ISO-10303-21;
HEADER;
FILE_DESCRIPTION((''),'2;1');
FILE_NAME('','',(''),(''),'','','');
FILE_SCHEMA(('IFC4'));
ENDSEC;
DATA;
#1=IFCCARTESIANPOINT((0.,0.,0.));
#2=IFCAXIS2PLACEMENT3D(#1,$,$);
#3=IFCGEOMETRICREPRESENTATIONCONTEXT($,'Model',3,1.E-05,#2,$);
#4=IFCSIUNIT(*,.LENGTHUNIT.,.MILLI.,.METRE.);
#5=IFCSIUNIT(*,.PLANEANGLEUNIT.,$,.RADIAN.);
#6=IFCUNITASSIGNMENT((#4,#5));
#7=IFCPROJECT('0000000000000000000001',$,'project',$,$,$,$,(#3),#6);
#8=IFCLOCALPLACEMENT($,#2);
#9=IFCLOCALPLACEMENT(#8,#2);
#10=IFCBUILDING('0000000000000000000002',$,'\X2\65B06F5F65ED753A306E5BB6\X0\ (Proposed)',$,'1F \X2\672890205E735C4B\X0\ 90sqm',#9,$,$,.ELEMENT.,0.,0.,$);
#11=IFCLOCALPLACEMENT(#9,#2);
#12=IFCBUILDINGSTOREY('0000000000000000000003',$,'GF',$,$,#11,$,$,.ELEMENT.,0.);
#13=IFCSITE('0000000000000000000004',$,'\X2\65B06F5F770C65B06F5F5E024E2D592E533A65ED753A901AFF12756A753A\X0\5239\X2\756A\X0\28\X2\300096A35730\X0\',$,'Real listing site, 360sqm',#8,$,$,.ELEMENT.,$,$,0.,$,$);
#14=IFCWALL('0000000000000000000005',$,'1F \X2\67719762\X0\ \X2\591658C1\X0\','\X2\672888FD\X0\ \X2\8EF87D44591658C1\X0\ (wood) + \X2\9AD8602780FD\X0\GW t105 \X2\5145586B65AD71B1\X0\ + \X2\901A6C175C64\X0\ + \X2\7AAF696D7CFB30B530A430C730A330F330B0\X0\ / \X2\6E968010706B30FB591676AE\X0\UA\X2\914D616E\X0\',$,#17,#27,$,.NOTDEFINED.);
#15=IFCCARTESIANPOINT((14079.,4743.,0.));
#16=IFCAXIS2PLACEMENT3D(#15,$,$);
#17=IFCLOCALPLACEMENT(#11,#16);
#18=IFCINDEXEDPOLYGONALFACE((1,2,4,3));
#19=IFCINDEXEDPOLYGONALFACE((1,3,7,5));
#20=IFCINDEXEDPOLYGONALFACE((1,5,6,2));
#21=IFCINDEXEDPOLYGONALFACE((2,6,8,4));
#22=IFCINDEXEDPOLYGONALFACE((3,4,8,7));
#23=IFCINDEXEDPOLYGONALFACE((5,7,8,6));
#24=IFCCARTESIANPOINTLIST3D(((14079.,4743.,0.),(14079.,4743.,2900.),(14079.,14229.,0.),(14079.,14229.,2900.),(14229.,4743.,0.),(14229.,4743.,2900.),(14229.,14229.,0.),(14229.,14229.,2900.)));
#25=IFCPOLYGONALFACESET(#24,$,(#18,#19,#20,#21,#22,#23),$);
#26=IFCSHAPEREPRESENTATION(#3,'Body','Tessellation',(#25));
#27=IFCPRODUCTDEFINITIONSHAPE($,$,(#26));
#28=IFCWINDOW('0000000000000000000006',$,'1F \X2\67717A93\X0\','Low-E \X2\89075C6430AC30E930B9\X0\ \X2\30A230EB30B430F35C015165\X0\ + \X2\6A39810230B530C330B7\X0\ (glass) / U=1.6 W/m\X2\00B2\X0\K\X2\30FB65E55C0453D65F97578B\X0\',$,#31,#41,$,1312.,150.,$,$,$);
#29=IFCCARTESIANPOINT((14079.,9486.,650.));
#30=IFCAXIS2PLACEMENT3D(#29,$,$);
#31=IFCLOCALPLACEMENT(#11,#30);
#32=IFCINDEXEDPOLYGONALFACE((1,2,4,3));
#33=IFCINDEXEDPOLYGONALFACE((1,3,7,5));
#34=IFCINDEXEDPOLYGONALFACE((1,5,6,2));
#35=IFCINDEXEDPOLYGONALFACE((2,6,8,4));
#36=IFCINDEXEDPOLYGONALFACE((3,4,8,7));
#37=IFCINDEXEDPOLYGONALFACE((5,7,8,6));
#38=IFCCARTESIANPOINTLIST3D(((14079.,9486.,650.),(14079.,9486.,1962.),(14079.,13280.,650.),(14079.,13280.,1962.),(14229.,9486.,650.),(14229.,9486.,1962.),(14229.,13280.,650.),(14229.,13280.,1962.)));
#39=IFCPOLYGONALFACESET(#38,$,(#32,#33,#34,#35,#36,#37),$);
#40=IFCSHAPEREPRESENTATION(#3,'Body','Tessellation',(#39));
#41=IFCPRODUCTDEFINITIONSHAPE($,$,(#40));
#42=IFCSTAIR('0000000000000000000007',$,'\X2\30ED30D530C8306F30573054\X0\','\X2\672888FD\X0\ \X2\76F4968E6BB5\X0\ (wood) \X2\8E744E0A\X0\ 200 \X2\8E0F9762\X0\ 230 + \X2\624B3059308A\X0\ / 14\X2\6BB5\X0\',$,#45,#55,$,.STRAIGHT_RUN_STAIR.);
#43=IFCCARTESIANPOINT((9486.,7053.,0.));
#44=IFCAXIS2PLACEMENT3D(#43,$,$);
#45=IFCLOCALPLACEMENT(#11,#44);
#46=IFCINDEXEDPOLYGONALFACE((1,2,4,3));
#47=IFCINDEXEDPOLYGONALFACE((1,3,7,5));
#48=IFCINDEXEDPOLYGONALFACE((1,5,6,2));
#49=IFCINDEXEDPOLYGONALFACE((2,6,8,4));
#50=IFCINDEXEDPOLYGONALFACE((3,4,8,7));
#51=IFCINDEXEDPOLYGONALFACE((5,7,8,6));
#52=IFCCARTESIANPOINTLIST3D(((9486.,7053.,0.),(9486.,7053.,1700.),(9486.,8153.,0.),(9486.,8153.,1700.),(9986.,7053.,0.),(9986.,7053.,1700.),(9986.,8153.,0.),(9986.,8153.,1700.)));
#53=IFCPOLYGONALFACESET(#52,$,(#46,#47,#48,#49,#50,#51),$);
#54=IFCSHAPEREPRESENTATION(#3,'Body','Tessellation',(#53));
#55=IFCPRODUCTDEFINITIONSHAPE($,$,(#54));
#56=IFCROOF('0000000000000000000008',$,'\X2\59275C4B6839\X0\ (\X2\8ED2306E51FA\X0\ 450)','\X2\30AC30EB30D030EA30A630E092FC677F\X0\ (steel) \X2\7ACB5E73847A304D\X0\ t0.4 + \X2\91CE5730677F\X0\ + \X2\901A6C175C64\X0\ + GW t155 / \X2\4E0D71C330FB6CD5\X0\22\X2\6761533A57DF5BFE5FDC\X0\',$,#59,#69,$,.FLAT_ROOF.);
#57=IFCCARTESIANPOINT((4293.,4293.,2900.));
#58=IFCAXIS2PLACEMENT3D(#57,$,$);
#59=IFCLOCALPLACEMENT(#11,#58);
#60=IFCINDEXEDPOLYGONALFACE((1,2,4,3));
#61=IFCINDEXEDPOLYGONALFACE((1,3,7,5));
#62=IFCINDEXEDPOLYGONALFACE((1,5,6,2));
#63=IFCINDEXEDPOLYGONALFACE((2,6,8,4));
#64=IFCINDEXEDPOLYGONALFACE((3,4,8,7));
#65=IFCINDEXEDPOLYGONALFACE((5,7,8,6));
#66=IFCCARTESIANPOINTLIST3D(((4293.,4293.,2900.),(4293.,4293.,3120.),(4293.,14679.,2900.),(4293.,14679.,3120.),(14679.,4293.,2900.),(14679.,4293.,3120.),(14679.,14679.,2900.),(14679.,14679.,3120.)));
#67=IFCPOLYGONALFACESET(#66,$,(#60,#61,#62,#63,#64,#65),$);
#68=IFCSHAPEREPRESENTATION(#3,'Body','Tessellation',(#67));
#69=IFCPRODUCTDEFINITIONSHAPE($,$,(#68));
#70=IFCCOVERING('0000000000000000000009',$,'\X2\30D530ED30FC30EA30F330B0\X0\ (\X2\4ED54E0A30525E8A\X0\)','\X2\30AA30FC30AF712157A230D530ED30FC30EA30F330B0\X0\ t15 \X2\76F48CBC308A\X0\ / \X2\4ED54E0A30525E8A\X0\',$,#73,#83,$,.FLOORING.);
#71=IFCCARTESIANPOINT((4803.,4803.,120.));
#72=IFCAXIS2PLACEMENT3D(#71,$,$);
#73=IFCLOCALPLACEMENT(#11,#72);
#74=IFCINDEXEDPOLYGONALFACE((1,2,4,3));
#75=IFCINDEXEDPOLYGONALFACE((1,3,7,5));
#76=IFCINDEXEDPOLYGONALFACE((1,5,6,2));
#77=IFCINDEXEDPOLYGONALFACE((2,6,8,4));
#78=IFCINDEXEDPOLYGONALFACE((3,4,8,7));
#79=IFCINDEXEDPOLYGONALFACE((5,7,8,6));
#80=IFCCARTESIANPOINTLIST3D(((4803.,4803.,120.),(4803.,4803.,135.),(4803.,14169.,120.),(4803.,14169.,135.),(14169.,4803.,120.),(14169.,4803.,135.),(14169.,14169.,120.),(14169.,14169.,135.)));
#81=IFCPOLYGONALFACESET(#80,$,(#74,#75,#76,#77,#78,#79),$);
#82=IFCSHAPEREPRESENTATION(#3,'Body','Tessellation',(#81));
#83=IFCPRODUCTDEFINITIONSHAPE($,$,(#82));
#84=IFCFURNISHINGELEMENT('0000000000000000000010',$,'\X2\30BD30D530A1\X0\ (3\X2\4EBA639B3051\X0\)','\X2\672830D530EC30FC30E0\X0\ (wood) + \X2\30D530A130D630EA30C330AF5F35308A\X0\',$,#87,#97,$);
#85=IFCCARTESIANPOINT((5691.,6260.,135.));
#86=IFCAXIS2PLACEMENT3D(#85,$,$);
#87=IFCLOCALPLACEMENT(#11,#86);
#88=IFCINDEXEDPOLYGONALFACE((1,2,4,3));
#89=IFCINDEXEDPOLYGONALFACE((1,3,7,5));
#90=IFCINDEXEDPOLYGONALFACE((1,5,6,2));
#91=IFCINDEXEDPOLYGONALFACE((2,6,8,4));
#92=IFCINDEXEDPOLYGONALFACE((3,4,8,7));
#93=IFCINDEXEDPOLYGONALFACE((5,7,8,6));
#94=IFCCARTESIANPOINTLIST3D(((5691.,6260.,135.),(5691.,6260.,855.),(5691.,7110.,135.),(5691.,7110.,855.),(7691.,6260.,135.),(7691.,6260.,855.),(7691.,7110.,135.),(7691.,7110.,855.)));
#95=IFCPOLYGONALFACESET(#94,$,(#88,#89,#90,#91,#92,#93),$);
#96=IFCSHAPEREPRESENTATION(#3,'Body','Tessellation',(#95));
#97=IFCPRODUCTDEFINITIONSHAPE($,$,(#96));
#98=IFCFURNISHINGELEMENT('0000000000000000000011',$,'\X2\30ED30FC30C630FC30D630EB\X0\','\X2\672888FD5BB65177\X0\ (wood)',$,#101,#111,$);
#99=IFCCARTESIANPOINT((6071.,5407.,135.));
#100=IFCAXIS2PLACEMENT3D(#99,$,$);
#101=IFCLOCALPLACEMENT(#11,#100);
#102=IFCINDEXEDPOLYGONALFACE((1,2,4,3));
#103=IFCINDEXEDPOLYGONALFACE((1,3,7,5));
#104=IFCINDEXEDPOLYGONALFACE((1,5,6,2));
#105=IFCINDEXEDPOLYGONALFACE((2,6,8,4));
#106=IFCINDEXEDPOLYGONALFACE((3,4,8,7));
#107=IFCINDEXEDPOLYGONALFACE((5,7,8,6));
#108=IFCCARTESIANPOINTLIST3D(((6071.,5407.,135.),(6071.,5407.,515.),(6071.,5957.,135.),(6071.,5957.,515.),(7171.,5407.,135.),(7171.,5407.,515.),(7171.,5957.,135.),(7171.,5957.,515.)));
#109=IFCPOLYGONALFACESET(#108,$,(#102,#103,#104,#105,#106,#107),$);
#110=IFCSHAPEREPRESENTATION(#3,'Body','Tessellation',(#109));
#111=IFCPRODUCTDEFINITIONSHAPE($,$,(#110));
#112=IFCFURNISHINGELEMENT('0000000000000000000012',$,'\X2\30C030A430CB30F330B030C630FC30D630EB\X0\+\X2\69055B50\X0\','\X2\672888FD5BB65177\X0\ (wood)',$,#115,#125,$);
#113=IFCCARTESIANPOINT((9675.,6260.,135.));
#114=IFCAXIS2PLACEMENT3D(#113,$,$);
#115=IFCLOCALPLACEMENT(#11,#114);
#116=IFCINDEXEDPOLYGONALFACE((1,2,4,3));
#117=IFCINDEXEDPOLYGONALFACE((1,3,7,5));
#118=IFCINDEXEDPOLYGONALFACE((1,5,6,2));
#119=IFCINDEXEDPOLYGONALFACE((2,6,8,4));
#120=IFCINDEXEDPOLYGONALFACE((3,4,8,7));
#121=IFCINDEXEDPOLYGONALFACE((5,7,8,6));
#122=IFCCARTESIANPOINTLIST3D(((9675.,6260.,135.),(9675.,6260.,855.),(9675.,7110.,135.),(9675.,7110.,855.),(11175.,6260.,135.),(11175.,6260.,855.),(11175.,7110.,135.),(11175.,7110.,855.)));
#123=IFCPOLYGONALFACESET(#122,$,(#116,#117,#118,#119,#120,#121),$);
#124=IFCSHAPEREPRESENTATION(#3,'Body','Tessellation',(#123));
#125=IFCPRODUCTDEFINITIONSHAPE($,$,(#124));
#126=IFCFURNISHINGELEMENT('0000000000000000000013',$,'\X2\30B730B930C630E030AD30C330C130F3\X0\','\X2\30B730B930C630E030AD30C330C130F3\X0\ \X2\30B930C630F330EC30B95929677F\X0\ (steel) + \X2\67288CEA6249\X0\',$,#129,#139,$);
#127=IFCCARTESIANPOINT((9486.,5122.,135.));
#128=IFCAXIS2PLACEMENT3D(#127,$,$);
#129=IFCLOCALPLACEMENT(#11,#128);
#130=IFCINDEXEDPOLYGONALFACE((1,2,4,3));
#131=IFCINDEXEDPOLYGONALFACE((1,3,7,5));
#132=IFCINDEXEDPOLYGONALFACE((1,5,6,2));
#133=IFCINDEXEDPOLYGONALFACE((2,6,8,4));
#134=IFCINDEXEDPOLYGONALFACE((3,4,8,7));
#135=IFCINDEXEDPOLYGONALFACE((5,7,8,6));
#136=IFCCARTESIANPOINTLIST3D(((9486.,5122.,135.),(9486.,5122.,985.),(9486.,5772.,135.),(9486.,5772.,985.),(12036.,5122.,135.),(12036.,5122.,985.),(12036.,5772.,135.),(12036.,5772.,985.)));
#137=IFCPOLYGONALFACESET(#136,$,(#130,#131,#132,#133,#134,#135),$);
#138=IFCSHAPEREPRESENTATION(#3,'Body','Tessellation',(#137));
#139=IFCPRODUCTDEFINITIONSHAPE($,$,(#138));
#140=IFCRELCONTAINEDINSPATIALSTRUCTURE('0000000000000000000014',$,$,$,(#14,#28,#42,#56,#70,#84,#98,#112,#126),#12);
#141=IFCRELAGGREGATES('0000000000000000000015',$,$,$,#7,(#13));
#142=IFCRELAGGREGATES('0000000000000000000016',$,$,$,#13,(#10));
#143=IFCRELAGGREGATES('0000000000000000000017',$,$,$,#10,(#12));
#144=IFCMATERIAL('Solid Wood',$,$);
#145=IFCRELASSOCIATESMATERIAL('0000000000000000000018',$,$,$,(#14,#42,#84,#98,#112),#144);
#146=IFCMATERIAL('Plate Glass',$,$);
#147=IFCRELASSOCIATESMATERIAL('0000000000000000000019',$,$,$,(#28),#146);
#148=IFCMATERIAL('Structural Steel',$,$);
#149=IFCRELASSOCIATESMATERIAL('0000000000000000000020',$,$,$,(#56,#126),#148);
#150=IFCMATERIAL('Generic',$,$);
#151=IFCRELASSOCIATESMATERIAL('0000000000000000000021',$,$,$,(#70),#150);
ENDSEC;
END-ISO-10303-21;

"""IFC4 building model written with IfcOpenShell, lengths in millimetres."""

from ifc_helpers import new_model, si_unit, frame, frame_2d, origin, place, context, project, spatial, rectangle, extrude, material, element, fill, save


model = new_model("IFC4")

# Units and contexts
model_context = context("Model", 3, precision=1e-05, world=origin())
ifc_project = project(units=[si_unit("LENGTHUNIT", "METRE", prefix="MILLI"), si_unit("PLANEANGLEUNIT", "RADIAN")], contexts=[model_context])

# Site, building, storey
site_placement = place(None, origin())
site = spatial("IfcSite", under=ifc_project, at=site_placement, Name="新潟県新潟市中央区旭町通２番町5239番28　隣地", ObjectType="Real listing site, 360sqm", CompositionType="ELEMENT", RefElevation=0.0)
building_placement = place(site_placement, origin())
building = spatial("IfcBuilding", under=site, at=building_placement, Name="新潟旭町の家 (Proposed)", ObjectType="1F 木造平屋 90sqm", CompositionType="ELEMENT", ElevationOfRefHeight=0.0, ElevationOfTerrain=0.0)
storey_placement = place(building_placement, origin())
storey = spatial("IfcBuildingStorey", under=building, at=storey_placement, Name="GF", CompositionType="ELEMENT", Elevation=0.0)

# Shared definitions
ifc_material_1 = material(Name="Solid Wood")

# Shared definitions
ifc_material_2 = material(Name="Plate Glass")

# Wall, opening, window
wall_1_placement = place(storey_placement, frame((14079.0, 4743.0, 0.0)))
wall_1 = element("IfcWall", 1, at=wall_1_placement, inside=storey, material=ifc_material_1, Name="1F 東面 外壁", Description="木製 軸組外壁 (wood) + 高性能GW t105 充填断熱 + 通気層 + 窯業系サイディング / 準耐火・外皮UA配慮", PredefinedType="NOTDEFINED", context=model_context, shape_type="SweptSolid", body=[
    extrude(rectangle(XDim=150.0, YDim=9486.0, at=frame_2d((75.0, 4743.0))), frame((14079.0, 4743.0, 0.0)), (0.0, 0.0, 1.0), 2900.0),
])
opening_1_placement = place(storey_placement, frame((14079.0, 9486.0, 650.0)))
opening_1 = element("IfcOpeningElement", 2, at=opening_1_placement, cuts=wall_1, PredefinedType="NOTDEFINED", context=model_context, shape_type="SweptSolid", body=[
    extrude(rectangle(XDim=150.0, YDim=3794.0, at=frame_2d((75.0, 1897.0))), frame((14079.0, 9486.0, 650.0)), (0.0, 0.0, 1.0), 1312.0),
])
window_1_placement = place(storey_placement, frame((14079.0, 9486.0, 650.0)))
window_1 = element("IfcWindow", 3, at=window_1_placement, inside=storey, material=ifc_material_2, Name="1F 東窓", Description="Low-E 複層ガラス アルゴン封入 + 樹脂サッシ (glass) / U=1.6 W/m²K・日射取得型", OverallHeight=1312.0, OverallWidth=150.0, context=model_context, shape_type="SweptSolid", body=[
    extrude(rectangle(XDim=150.0, YDim=3794.0, at=frame_2d((75.0, 1897.0))), frame((14079.0, 9486.0, 650.0)), (0.0, 0.0, 1.0), 1312.0),
])
fill(opening_1, window_1)

# Stair
stair_placement = place(storey_placement, frame((9486.0, 7053.0, 0.0)))
element("IfcStair", 4, at=stair_placement, inside=storey, material=ifc_material_1, Name="ロフトはしご", Description="木製 直階段 (wood) 蹴上 200 踏面 230 + 手すり / 14段", PredefinedType="STRAIGHT_RUN_STAIR", context=model_context, shape_type="SweptSolid", body=[
    extrude(rectangle(XDim=500.0, YDim=1100.0, at=frame_2d((250.0, 550.0))), frame((9486.0, 7053.0, 0.0)), (0.0, 0.0, 1.0), 1700.0),
])

# Roof
ifc_material_3 = material(Name="Structural Steel")
roof_placement = place(storey_placement, frame((4293.0, 4293.0, 2900.0)))
element("IfcRoof", 5, at=roof_placement, inside=storey, material=ifc_material_3, Name="大屋根 (軒の出 450)", Description="ガルバリウム鋼板 (steel) 立平葺き t0.4 + 野地板 + 通気層 + GW t155 / 不燃・法22条区域対応", PredefinedType="FLAT_ROOF", context=model_context, shape_type="SweptSolid", body=[
    extrude(rectangle(XDim=10386.0, YDim=10386.0, at=frame_2d((5193.0, 5193.0))), frame((4293.0, 4293.0, 2900.0)), (0.0, 0.0, 1.0), 220.0),
])

# Covering
ifc_material_4 = material(Name="Generic")
covering_placement = place(storey_placement, frame((4803.0, 4803.0, 120.0)))
element("IfcCovering", 6, at=covering_placement, inside=storey, material=ifc_material_4, Name="フローリング (仕上げ床)", Description="オーク無垢フローリング t15 直貼り / 仕上げ床", PredefinedType="FLOORING", context=model_context, shape_type="SweptSolid", body=[
    extrude(rectangle(XDim=9366.0, YDim=9366.0, at=frame_2d((4683.0, 4683.0))), frame((4803.0, 4803.0, 120.0)), (0.0, 0.0, 1.0), 15.0),
])

# Furnishing elements
furnishing_1_placement = place(storey_placement, frame((5691.0, 6260.0, 135.0)))
element("IfcFurnishingElement", 7, at=furnishing_1_placement, inside=storey, material=ifc_material_1, Name="ソファ (3人掛け)", Description="木フレーム (wood) + ファブリック張り", context=model_context, shape_type="SweptSolid", body=[
    extrude(rectangle(XDim=2000.0, YDim=850.0, at=frame_2d((1000.0, 425.0))), frame((5691.0, 6260.0, 135.0)), (0.0, 0.0, 1.0), 720.0),
])
furnishing_2_placement = place(storey_placement, frame((6071.0, 5407.0, 135.0)))
element("IfcFurnishingElement", 8, at=furnishing_2_placement, inside=storey, material=ifc_material_1, Name="ローテーブル", Description="木製家具 (wood)", context=model_context, shape_type="SweptSolid", body=[
    extrude(rectangle(XDim=1100.0, YDim=550.0, at=frame_2d((550.0, 275.0))), frame((6071.0, 5407.0, 135.0)), (0.0, 0.0, 1.0), 380.0),
])
furnishing_3_placement = place(storey_placement, frame((9675.0, 6260.0, 135.0)))
element("IfcFurnishingElement", 9, at=furnishing_3_placement, inside=storey, material=ifc_material_1, Name="ダイニングテーブル+椅子", Description="木製家具 (wood)", context=model_context, shape_type="SweptSolid", body=[
    extrude(rectangle(XDim=1500.0, YDim=850.0, at=frame_2d((750.0, 425.0))), frame((9675.0, 6260.0, 135.0)), (0.0, 0.0, 1.0), 720.0),
])
furnishing_4_placement = place(storey_placement, frame((9486.0, 5122.0, 135.0)))
element("IfcFurnishingElement", 10, at=furnishing_4_placement, inside=storey, material=ifc_material_3, Name="システムキッチン", Description="システムキッチン ステンレス天板 (steel) + 木質扉", context=model_context, shape_type="SweptSolid", body=[
    extrude(rectangle(XDim=2550.0, YDim=650.0, at=frame_2d((1275.0, 325.0))), frame((9486.0, 5122.0, 135.0)), (0.0, 0.0, 1.0), 850.0),
])

save(model, "model.ifc")
